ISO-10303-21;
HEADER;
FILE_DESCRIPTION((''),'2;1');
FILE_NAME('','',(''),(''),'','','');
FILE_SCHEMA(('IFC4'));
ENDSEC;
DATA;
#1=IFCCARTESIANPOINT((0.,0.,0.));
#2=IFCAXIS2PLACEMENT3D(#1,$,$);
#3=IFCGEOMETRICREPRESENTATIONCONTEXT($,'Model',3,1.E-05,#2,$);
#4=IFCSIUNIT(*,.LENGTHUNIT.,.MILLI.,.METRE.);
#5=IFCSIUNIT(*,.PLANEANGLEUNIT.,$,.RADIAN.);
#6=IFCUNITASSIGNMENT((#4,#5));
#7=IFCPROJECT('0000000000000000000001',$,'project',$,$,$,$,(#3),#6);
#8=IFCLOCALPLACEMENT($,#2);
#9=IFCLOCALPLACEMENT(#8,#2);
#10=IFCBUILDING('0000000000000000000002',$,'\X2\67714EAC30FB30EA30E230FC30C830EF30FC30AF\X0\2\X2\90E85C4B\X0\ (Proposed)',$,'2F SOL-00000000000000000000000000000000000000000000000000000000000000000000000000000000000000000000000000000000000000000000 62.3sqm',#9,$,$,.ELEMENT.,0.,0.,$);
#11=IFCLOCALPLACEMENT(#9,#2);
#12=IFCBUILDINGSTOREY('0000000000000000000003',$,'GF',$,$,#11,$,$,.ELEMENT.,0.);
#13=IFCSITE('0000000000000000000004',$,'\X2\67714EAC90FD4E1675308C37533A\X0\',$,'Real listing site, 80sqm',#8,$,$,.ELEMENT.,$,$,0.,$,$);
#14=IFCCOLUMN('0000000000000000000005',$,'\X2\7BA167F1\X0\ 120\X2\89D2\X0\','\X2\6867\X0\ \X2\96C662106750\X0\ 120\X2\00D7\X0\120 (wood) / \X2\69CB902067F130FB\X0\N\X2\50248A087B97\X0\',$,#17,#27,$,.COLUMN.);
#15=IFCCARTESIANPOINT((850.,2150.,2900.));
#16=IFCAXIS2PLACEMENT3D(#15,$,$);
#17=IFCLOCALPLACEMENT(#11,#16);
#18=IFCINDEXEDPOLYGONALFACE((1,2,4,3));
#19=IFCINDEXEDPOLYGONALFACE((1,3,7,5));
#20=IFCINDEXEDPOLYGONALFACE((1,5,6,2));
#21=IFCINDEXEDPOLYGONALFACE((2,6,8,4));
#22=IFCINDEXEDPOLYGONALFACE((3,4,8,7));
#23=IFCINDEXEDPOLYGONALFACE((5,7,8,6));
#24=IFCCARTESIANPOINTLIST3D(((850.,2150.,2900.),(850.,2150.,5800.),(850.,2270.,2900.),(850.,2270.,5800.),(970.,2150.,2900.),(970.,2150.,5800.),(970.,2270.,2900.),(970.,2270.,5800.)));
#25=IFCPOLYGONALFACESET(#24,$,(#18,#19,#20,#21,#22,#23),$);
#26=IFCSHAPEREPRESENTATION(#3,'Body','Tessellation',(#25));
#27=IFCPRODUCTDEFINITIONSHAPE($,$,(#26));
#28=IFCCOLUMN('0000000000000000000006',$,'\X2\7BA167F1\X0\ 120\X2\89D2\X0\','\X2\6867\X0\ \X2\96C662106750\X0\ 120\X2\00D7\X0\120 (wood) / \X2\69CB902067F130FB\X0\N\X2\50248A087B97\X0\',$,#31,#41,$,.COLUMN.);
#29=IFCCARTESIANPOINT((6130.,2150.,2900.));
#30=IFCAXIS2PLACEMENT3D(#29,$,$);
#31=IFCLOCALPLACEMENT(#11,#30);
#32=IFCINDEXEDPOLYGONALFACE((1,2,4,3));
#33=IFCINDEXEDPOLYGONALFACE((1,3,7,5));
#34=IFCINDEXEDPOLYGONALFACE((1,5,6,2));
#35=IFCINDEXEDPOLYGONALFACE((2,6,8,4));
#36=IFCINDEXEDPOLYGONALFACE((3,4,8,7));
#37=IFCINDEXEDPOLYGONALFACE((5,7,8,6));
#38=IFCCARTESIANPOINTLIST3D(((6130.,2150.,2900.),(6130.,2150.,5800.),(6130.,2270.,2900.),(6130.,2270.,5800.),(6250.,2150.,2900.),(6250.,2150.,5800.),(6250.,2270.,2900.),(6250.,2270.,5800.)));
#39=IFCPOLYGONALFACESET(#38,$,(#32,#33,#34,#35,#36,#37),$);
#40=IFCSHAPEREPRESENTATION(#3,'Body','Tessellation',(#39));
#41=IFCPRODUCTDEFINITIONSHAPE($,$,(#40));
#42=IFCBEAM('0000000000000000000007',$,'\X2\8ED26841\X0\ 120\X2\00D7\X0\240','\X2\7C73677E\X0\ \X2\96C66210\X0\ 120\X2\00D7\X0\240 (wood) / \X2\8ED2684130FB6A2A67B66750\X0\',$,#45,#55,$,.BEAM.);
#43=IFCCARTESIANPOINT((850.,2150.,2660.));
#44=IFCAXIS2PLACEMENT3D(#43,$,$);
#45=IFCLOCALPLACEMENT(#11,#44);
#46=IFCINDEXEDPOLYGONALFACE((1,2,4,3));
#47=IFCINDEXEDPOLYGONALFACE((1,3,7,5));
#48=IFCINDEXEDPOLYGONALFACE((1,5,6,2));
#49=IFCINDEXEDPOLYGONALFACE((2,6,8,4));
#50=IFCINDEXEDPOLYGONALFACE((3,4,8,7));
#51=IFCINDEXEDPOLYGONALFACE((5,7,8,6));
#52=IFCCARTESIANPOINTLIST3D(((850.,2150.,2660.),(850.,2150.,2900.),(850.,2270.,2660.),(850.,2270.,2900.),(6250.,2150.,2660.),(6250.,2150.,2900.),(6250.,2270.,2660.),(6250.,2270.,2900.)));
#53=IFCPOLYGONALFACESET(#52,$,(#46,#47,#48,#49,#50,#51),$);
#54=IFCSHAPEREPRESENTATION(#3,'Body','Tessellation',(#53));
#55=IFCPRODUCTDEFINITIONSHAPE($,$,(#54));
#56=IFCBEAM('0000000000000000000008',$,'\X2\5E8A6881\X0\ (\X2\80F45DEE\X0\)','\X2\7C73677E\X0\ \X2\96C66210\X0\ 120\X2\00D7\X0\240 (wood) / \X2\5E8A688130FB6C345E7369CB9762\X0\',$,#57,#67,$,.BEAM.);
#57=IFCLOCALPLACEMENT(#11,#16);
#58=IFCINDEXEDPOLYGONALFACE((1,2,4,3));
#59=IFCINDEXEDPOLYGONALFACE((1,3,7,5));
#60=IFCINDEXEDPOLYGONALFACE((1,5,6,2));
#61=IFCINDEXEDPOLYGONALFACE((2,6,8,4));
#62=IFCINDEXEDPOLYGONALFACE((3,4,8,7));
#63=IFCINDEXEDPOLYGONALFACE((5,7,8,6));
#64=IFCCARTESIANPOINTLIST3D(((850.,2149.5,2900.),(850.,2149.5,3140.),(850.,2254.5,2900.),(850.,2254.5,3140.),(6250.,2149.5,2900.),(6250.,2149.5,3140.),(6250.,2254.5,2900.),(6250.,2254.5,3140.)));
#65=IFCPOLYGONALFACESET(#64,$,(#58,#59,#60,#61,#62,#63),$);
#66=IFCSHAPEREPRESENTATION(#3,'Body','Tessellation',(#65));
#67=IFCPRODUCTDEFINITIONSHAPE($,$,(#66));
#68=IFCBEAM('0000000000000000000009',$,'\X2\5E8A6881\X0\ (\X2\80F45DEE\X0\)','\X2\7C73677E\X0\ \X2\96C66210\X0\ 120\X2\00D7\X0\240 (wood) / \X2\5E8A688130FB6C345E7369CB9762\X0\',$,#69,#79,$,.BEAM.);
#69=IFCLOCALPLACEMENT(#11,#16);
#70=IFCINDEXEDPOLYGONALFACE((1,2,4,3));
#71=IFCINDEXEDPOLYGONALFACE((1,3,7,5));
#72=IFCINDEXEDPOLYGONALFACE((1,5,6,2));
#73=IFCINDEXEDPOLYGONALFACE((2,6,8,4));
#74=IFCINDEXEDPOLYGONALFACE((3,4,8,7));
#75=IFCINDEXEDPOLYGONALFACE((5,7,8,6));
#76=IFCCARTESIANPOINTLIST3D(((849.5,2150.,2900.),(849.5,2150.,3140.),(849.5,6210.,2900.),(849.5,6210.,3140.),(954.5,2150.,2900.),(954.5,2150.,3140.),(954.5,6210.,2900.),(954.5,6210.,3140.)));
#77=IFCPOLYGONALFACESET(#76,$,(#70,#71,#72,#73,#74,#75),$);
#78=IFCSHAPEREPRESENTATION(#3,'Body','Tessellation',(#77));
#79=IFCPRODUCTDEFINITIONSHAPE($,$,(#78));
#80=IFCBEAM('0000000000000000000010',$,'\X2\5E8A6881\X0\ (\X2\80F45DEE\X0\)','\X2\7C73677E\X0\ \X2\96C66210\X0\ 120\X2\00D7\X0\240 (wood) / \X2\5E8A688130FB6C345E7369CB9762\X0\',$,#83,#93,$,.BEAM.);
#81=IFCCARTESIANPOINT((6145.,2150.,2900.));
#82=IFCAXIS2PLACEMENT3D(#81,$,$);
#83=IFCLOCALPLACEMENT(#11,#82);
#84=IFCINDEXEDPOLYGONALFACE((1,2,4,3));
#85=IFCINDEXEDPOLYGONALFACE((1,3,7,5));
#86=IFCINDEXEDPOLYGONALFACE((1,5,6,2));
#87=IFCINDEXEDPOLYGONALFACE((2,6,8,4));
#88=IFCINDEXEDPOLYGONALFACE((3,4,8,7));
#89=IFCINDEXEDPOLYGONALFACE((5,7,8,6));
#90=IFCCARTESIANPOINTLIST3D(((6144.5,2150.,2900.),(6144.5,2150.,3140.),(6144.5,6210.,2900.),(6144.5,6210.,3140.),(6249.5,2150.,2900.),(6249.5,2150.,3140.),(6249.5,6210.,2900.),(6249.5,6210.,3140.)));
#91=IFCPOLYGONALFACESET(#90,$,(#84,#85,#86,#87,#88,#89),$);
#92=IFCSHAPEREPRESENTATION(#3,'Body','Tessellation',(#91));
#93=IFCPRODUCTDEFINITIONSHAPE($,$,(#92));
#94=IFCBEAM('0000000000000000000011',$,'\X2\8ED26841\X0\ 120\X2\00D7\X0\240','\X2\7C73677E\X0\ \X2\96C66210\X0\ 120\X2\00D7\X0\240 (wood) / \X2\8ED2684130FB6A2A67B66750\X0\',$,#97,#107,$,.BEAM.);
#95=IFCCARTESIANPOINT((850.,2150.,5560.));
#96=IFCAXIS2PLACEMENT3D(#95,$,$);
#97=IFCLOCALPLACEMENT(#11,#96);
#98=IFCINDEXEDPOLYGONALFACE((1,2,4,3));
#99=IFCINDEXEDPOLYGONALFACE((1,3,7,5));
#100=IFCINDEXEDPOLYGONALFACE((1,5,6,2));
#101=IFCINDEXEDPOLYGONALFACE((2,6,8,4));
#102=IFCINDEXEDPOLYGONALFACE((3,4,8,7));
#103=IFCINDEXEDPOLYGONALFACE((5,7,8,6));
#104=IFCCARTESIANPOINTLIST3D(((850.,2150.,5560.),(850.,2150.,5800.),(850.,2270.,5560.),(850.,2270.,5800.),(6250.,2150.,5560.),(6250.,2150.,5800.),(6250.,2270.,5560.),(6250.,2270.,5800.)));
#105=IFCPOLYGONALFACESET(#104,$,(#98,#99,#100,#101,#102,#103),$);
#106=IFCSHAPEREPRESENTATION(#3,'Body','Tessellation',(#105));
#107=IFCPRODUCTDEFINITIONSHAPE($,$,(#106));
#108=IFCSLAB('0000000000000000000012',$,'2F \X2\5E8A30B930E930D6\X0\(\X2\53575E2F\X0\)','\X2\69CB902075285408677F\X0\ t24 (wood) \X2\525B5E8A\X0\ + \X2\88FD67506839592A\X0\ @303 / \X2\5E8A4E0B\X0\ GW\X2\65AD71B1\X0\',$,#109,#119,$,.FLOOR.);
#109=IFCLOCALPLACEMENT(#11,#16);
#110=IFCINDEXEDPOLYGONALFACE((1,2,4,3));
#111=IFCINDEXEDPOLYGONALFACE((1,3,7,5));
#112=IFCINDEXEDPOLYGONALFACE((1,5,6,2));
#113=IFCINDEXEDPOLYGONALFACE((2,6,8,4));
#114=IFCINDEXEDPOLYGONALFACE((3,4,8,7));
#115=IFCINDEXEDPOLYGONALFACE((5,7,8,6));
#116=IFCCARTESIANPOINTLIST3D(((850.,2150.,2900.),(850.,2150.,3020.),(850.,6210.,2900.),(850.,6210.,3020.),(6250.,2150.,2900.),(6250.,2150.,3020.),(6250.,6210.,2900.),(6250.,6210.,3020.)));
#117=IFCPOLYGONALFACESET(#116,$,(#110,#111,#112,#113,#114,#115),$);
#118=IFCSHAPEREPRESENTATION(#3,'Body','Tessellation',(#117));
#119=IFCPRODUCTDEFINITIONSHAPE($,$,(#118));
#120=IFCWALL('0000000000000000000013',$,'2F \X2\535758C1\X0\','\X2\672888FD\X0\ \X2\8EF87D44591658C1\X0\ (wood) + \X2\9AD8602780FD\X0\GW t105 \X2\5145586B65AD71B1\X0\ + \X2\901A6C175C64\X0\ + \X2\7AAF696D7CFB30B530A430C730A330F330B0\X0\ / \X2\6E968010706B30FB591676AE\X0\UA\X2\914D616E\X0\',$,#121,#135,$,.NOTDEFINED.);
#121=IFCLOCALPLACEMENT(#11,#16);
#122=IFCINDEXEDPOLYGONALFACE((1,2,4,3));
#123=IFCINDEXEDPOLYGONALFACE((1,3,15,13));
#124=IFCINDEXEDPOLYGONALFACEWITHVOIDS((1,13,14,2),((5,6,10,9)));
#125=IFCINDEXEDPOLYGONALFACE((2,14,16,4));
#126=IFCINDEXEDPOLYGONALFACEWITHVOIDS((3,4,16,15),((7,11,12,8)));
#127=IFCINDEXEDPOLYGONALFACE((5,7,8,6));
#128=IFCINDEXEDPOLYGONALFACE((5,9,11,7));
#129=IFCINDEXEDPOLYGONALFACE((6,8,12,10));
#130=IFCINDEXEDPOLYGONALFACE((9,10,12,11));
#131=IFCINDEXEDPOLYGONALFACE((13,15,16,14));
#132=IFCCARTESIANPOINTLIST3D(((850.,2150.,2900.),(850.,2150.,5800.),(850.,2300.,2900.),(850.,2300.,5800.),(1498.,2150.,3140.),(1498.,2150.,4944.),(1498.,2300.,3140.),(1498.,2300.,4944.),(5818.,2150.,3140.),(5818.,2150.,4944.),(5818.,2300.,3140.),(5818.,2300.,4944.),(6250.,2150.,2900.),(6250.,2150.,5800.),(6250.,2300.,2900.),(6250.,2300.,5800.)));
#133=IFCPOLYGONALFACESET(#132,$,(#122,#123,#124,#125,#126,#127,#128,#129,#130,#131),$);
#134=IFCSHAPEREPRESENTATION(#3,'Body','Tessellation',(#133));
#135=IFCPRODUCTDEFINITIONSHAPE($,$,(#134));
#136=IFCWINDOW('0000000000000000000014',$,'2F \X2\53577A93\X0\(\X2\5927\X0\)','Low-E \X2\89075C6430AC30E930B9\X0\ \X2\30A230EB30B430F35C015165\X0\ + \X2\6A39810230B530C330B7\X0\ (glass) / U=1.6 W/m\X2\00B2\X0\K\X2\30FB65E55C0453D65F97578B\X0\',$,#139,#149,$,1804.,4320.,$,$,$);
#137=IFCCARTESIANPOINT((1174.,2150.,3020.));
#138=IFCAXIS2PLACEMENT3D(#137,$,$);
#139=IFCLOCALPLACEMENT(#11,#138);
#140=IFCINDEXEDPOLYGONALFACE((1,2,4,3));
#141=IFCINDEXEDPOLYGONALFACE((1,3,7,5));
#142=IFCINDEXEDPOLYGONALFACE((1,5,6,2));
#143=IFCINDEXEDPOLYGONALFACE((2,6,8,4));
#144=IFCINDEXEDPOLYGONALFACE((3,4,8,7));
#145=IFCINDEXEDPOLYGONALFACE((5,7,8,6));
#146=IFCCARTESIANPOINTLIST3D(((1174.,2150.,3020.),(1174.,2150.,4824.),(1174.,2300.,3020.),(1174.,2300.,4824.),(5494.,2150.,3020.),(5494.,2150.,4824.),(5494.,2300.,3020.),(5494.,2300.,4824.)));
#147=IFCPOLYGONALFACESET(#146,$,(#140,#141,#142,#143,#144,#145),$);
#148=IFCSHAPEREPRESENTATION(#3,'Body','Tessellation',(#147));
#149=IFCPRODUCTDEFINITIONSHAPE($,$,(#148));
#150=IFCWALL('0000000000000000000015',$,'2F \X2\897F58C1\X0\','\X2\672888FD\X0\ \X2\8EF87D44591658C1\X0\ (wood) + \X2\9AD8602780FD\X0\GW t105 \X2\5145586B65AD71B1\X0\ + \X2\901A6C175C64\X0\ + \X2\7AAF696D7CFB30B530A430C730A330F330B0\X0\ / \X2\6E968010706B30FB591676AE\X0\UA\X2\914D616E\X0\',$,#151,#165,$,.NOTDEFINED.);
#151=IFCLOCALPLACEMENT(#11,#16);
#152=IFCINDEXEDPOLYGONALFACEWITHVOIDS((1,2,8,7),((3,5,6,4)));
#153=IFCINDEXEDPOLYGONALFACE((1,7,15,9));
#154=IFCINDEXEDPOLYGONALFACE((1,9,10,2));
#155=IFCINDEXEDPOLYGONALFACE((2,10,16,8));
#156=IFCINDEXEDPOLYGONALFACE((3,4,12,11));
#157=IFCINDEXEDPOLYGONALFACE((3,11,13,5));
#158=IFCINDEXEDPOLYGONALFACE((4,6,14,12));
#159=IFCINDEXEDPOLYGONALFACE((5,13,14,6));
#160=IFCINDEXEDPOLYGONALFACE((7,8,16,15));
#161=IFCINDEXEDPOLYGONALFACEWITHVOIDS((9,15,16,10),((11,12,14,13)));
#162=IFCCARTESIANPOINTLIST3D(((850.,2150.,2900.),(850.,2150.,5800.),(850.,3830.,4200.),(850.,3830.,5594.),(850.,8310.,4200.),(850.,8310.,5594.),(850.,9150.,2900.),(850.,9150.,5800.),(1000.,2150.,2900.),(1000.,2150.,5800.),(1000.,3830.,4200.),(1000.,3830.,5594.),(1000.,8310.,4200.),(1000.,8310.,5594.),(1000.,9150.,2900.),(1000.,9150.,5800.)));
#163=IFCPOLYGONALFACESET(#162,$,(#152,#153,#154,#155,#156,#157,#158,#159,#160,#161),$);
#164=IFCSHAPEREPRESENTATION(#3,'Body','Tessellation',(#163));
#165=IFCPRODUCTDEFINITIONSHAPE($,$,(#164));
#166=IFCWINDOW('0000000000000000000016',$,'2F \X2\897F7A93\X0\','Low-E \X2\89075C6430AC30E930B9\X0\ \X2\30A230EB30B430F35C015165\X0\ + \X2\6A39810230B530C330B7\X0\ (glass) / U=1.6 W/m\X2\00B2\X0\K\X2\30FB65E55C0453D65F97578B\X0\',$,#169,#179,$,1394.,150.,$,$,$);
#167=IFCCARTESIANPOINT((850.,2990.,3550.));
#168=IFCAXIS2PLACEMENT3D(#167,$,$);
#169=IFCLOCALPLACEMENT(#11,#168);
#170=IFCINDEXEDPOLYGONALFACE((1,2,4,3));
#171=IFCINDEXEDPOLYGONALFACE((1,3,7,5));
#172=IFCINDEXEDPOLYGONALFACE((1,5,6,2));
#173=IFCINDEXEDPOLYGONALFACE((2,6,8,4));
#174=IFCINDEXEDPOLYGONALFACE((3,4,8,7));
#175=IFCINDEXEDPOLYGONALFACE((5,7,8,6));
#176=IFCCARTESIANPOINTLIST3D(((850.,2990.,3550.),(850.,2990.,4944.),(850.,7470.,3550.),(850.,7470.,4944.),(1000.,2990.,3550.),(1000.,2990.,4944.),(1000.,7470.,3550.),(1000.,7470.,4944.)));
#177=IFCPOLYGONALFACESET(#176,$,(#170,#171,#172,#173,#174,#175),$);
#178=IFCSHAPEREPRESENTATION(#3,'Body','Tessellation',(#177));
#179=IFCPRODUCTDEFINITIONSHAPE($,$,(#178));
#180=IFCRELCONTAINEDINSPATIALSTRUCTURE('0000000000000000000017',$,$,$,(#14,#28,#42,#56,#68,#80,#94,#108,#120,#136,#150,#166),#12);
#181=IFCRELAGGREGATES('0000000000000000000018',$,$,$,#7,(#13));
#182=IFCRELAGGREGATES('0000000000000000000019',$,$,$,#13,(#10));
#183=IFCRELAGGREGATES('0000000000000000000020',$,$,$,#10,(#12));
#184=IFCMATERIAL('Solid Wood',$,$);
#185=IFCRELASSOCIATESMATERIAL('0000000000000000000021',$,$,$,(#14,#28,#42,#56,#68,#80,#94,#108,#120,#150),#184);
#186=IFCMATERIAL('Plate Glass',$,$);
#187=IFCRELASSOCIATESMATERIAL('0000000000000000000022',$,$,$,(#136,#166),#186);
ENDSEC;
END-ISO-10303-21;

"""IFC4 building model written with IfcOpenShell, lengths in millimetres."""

from ifc_helpers import new_model, si_unit, frame, frame_2d, origin, place, context, project, spatial, rectangle, extrude, material, element, fill, save


model = new_model("IFC4")

# Units and contexts
model_context = context("Model", 3, precision=1e-05, world=origin())
ifc_project = project(units=[si_unit("LENGTHUNIT", "METRE", prefix="MILLI"), si_unit("PLANEANGLEUNIT", "RADIAN")], contexts=[model_context])

# Site, building, storey
site_placement = place(None, origin())
site = spatial("IfcSite", under=ifc_project, at=site_placement, Name="東京都世田谷区", ObjectType="Real listing site, 80sqm", CompositionType="ELEMENT", RefElevation=0.0)
building_placement = place(site_placement, origin())
building = spatial("IfcBuilding", under=site, at=building_placement, Name="東京・リモートワーク2部屋 (Proposed)", ObjectType="2F SOL-00000000000000000000000000000000000000000000000000000000000000000000000000000000000000000000000000000000000000000000 62.3sqm", CompositionType="ELEMENT", ElevationOfRefHeight=0.0, ElevationOfTerrain=0.0)
storey_placement = place(building_placement, origin())
storey = spatial("IfcBuildingStorey", under=building, at=storey_placement, Name="GF", CompositionType="ELEMENT", Elevation=0.0)

# Columns
ifc_material_1 = material(Name="Solid Wood")
column_1_placement = place(storey_placement, frame((850.0, 2150.0, 2900.0)))
element("IfcColumn", 1, at=column_1_placement, inside=storey, material=ifc_material_1, Name="管柱 120角", Description="桧 集成材 120×120 (wood) / 構造柱・N値計算", PredefinedType="COLUMN", context=model_context, shape_type="SweptSolid", body=[
    extrude(rectangle(XDim=120.0, YDim=120.0, at=frame_2d((60.0, 60.0))), frame((850.0, 2150.0, 2900.0)), (0.0, 0.0, 1.0), 2900.0),
])
column_2_placement = place(storey_placement, frame((6130.0, 2150.0, 2900.0)))
element("IfcColumn", 2, at=column_2_placement, inside=storey, material=ifc_material_1, Name="管柱 120角", Description="桧 集成材 120×120 (wood) / 構造柱・N値計算", PredefinedType="COLUMN", context=model_context, shape_type="SweptSolid", body=[
    extrude(rectangle(XDim=120.0, YDim=120.0, at=frame_2d((60.0, 60.0))), frame((6130.0, 2150.0, 2900.0)), (0.0, 0.0, 1.0), 2900.0),
])

# Beams
beam_1_placement = place(storey_placement, frame((850.0, 2150.0, 2660.0)))
element("IfcBeam", 3, at=beam_1_placement, inside=storey, material=ifc_material_1, Name="軒桁 120×240", Description="米松 集成 120×240 (wood) / 軒桁・横架材", PredefinedType="BEAM", context=model_context, shape_type="SweptSolid", body=[
    extrude(rectangle(XDim=5400.0, YDim=120.0, at=frame_2d((2700.0, 60.0))), frame((850.0, 2150.0, 2660.0)), (0.0, 0.0, 1.0), 240.0),
])
beam_2_placement = place(storey_placement, frame((850.0, 2150.0, 2900.0)))
element("IfcBeam", 4, at=beam_2_placement, inside=storey, material=ifc_material_1, Name="床梁 (胴差)", Description="米松 集成 120×240 (wood) / 床梁・水平構面", PredefinedType="BEAM", context=model_context, shape_type="SweptSolid", body=[
    extrude(rectangle(XDim=5400.0, YDim=105.0, at=frame_2d((2700.0, 52.0))), frame((850.0, 2150.0, 2900.0)), (0.0, 0.0, 1.0), 240.0),
])
beam_3_placement = place(storey_placement, frame((850.0, 2150.0, 2900.0)))
element("IfcBeam", 5, at=beam_3_placement, inside=storey, material=ifc_material_1, Name="床梁 (胴差)", Description="米松 集成 120×240 (wood) / 床梁・水平構面", PredefinedType="BEAM", context=model_context, shape_type="SweptSolid", body=[
    extrude(rectangle(XDim=105.0, YDim=4060.0, at=frame_2d((52.0, 2030.0))), frame((850.0, 2150.0, 2900.0)), (0.0, 0.0, 1.0), 240.0),
])
beam_4_placement = place(storey_placement, frame((6145.0, 2150.0, 2900.0)))
element("IfcBeam", 6, at=beam_4_placement, inside=storey, material=ifc_material_1, Name="床梁 (胴差)", Description="米松 集成 120×240 (wood) / 床梁・水平構面", PredefinedType="BEAM", context=model_context, shape_type="SweptSolid", body=[
    extrude(rectangle(XDim=105.0, YDim=4060.0, at=frame_2d((52.0, 2030.0))), frame((6145.0, 2150.0, 2900.0)), (0.0, 0.0, 1.0), 240.0),
])
beam_5_placement = place(storey_placement, frame((850.0, 2150.0, 5560.0)))
element("IfcBeam", 7, at=beam_5_placement, inside=storey, material=ifc_material_1, Name="軒桁 120×240", Description="米松 集成 120×240 (wood) / 軒桁・横架材", PredefinedType="BEAM", context=model_context, shape_type="SweptSolid", body=[
    extrude(rectangle(XDim=5400.0, YDim=120.0, at=frame_2d((2700.0, 60.0))), frame((850.0, 2150.0, 5560.0)), (0.0, 0.0, 1.0), 240.0),
])

# Slab
slab_placement = place(storey_placement, frame((850.0, 2150.0, 2900.0)))
element("IfcSlab", 8, at=slab_placement, inside=storey, material=ifc_material_1, Name="2F 床スラブ(南帯)", Description="構造用合板 t24 (wood) 剛床 + 製材根太 @303 / 床下 GW断熱", PredefinedType="FLOOR", context=model_context, shape_type="SweptSolid", body=[
    extrude(rectangle(XDim=5400.0, YDim=4060.0, at=frame_2d((2700.0, 2030.0))), frame((850.0, 2150.0, 2900.0)), (0.0, 0.0, 1.0), 120.0),
])

# Walls, openings, windows
wall_1_placement = place(storey_placement, frame((850.0, 2150.0, 2900.0)))
wall_1 = element("IfcWall", 9, at=wall_1_placement, inside=storey, material=ifc_material_1, Name="2F 南壁", Description="木製 軸組外壁 (wood) + 高性能GW t105 充填断熱 + 通気層 + 窯業系サイディング / 準耐火・外皮UA配慮", PredefinedType="NOTDEFINED", context=model_context, shape_type="SweptSolid", body=[
    extrude(rectangle(XDim=5400.0, YDim=150.0, at=frame_2d((2700.0, 75.0))), frame((850.0, 2150.0, 2900.0)), (0.0, 0.0, 1.0), 2900.0),
])
opening_1_placement = place(storey_placement, frame((1174.0, 2150.0, 3020.0)))
opening_1 = element("IfcOpeningElement", 10, at=opening_1_placement, cuts=wall_1, PredefinedType="NOTDEFINED", context=model_context, shape_type="SweptSolid", body=[
    extrude(rectangle(XDim=4320.0, YDim=150.0, at=frame_2d((2160.0, 75.0))), frame((1174.0, 2150.0, 3020.0)), (0.0, 0.0, 1.0), 1804.0),
])
ifc_material_2 = material(Name="Plate Glass")
window_1_placement = place(storey_placement, frame((1174.0, 2150.0, 3020.0)))
window_1 = element("IfcWindow", 11, at=window_1_placement, inside=storey, material=ifc_material_2, Name="2F 南窓(大)", Description="Low-E 複層ガラス アルゴン封入 + 樹脂サッシ (glass) / U=1.6 W/m²K・日射取得型", OverallHeight=1804.0, OverallWidth=4320.0, context=model_context, shape_type="SweptSolid", body=[
    extrude(rectangle(XDim=4320.0, YDim=150.0, at=frame_2d((2160.0, 75.0))), frame((1174.0, 2150.0, 3020.0)), (0.0, 0.0, 1.0), 1804.0),
])
fill(opening_1, window_1)
wall_2_placement = place(storey_placement, frame((850.0, 2150.0, 2900.0)))
wall_2 = element("IfcWall", 12, at=wall_2_placement, inside=storey, material=ifc_material_1, Name="2F 西壁", Description="木製 軸組外壁 (wood) + 高性能GW t105 充填断熱 + 通気層 + 窯業系サイディング / 準耐火・外皮UA配慮", PredefinedType="NOTDEFINED", context=model_context, shape_type="SweptSolid", body=[
    extrude(rectangle(XDim=150.0, YDim=7000.0, at=frame_2d((75.0, 3500.0))), frame((850.0, 2150.0, 2900.0)), (0.0, 0.0, 1.0), 2900.0),
])
opening_2_placement = place(storey_placement, frame((850.0, 2990.0, 3550.0)))
opening_2 = element("IfcOpeningElement", 13, at=opening_2_placement, cuts=wall_2, PredefinedType="NOTDEFINED", context=model_context, shape_type="SweptSolid", body=[
    extrude(rectangle(XDim=150.0, YDim=4480.0, at=frame_2d((75.0, 2240.0))), frame((850.0, 2990.0, 3550.0)), (0.0, 0.0, 1.0), 1394.0),
])
window_2_placement = place(storey_placement, frame((850.0, 2990.0, 3550.0)))
window_2 = element("IfcWindow", 14, at=window_2_placement, inside=storey, material=ifc_material_2, Name="2F 西窓", Description="Low-E 複層ガラス アルゴン封入 + 樹脂サッシ (glass) / U=1.6 W/m²K・日射取得型", OverallHeight=1394.0, OverallWidth=150.0, context=model_context, shape_type="SweptSolid", body=[
    extrude(rectangle(XDim=150.0, YDim=4480.0, at=frame_2d((75.0, 2240.0))), frame((850.0, 2990.0, 3550.0)), (0.0, 0.0, 1.0), 1394.0),
])
fill(opening_2, window_2)

save(model, "model.ifc")
